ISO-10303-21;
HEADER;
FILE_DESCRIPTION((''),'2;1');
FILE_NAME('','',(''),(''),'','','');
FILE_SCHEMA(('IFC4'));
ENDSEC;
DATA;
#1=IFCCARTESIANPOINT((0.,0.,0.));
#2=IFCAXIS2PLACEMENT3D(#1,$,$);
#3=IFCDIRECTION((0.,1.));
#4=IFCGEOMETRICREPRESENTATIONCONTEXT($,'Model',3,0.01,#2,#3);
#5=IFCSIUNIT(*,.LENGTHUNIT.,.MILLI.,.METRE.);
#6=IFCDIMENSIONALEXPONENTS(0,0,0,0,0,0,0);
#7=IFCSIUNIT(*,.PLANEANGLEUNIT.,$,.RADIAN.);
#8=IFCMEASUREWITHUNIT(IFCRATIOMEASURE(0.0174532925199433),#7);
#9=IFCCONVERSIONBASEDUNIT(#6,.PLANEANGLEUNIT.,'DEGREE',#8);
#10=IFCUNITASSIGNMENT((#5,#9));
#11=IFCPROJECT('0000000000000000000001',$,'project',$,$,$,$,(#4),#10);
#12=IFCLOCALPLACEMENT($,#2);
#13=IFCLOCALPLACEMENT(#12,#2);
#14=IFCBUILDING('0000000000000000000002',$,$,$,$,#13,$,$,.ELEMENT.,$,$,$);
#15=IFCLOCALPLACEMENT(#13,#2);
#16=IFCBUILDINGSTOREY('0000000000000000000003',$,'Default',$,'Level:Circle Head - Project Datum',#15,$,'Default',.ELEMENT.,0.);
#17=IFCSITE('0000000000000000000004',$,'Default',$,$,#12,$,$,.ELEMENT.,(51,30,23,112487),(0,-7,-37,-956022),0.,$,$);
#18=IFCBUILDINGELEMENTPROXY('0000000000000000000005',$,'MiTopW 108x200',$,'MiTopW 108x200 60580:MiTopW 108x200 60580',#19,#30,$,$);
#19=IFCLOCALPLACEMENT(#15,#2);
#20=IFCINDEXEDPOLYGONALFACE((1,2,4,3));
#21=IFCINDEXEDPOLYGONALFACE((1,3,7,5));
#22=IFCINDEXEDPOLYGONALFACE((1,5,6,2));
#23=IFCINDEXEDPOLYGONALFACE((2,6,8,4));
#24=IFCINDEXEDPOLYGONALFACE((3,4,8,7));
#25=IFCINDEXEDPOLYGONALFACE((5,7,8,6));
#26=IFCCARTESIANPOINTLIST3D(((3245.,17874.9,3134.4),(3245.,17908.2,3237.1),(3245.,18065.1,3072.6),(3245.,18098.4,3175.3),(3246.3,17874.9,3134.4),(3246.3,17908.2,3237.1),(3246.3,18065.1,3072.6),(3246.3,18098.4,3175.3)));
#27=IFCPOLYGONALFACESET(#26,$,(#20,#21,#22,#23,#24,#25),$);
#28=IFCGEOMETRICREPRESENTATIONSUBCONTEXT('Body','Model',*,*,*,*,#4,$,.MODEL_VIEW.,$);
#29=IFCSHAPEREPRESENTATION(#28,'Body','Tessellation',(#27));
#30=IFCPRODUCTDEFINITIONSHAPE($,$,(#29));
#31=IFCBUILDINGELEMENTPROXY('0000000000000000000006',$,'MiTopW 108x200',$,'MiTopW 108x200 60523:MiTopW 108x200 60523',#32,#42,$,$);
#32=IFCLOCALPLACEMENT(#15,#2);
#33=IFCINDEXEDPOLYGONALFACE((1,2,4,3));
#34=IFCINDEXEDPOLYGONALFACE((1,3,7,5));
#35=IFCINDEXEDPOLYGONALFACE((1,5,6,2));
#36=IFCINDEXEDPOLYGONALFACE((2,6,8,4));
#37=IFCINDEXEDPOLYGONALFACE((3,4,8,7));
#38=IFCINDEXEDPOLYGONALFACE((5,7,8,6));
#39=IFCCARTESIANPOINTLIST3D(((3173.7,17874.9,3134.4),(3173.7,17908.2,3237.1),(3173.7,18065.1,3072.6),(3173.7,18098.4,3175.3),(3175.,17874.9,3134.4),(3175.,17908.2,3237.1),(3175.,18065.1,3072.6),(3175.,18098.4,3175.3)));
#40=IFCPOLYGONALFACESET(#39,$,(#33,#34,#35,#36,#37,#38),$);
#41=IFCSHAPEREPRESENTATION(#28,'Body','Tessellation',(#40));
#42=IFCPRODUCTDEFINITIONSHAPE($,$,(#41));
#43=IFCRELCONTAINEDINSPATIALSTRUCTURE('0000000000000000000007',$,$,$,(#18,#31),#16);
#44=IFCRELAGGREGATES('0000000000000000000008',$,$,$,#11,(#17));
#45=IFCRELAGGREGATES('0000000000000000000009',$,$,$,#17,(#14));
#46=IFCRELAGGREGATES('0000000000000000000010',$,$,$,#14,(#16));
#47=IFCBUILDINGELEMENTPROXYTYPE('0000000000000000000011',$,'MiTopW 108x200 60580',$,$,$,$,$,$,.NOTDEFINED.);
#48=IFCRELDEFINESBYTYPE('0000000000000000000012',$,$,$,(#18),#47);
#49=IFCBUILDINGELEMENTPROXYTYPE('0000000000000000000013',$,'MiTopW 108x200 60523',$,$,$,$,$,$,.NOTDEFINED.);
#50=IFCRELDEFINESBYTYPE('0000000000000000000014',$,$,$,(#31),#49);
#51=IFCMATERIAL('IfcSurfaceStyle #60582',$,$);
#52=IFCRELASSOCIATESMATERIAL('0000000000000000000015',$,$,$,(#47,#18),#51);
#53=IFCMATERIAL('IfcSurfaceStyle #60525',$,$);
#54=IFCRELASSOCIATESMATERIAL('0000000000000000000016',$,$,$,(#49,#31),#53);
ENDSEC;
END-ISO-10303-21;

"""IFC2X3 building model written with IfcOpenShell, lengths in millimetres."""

from ifc_helpers import new_model, entity, si_unit, converted_unit, direction, frame, origin, place, context, subcontext, project, spatial, polyline, outline, extrude, source, transform, mapped, material, type_object, type_shapes, element, save


model = new_model("IFC2X3")

# Units and contexts
model_context = context("Model", 3, precision=0.01, world=origin(), true_north=direction((0.0, 1.0)))
body_context = subcontext(model_context, "Body", "Model", "MODEL_VIEW")
ifc_project = project(units=[si_unit("LENGTHUNIT", "METRE", prefix="MILLI"), converted_unit("PLANEANGLEUNIT", "DEGREE", entity("IfcRatioMeasure", 0.0174532925199433), si_unit("PLANEANGLEUNIT", "RADIAN"), dimensions=[0, 0, 0, 0, 0, 0, 0])], contexts=[model_context])

# Site, building, storey
site_placement = place(None, origin())
site = spatial("IfcSite", under=ifc_project, at=site_placement, Name="Default", CompositionType="ELEMENT", RefLatitude=(51, 30, 23, 112487), RefLongitude=(0, -7, -37, -956022), RefElevation=0.0)
building_placement = place(site_placement, origin())
building = spatial("IfcBuilding", under=site, at=building_placement, CompositionType="ELEMENT")
storey_placement = place(building_placement, origin())
storey = spatial("IfcBuildingStorey", under=building, at=storey_placement, Name="Default", ObjectType="Level:Circle Head - Project Datum", LongName="Default", CompositionType="ELEMENT", Elevation=0.0)

# Building element proxies
ifc_material_1 = material(Name="IfcSurfaceStyle #60582")
building_element_proxy_type_1 = type_object("IfcBuildingElementProxyType", Name="MiTopW 108x200 60580", PredefinedType="NOTDEFINED", material=ifc_material_1)
shared_shape_1 = source(origin(), body_context, "Body", "SweptSolid", [
    extrude(outline(polyline([(-100.0, -54.0), (100.0, -54.0), (100.0, 54.0), (-100.0, 54.0), (-100.0, -54.0)])), frame((100.0, 54.0, 0.0), z_axis=(0.0, 0.0, 1.0), x_axis=(-1.0, 0.0, 0.0)), (0.0, 0.0, 1.0), 1.3),
])
type_shapes(building_element_proxy_type_1, [shared_shape_1])
proxy_1_placement = place(building_placement, frame((3246.3, 18065.1, 3072.6), z_axis=(-1.0, 0.0, 0.0), x_axis=(0.0, -0.951057, 0.309017)))
element("IfcBuildingElementProxy", 1, at=proxy_1_placement, inside=storey, type_object=building_element_proxy_type_1, material=ifc_material_1, Name="MiTopW 108x200", ObjectType="MiTopW 108x200 60580:MiTopW 108x200 60580", context=body_context, shape_type="MappedRepresentation", body=[
    mapped(shared_shape_1, transform((0.0, 0.0, 0.0), scale=1.0)),
])
ifc_material_2 = material(Name="IfcSurfaceStyle #60525")
building_element_proxy_type_2 = type_object("IfcBuildingElementProxyType", Name="MiTopW 108x200 60523", PredefinedType="NOTDEFINED", material=ifc_material_2)
shared_shape_2 = source(origin(), body_context, "Body", "SweptSolid", [
    extrude(outline(polyline([(-100.0, -54.0), (100.0, -54.0), (100.0, 54.0), (-100.0, 54.0), (-100.0, -54.0)])), frame((100.0, 54.0, 0.0), z_axis=(0.0, 0.0, 1.0), x_axis=(-1.0, 0.0, 0.0)), (0.0, 0.0, 1.0), 1.3),
])
type_shapes(building_element_proxy_type_2, [shared_shape_2])
proxy_2_placement = place(building_placement, frame((3175.0, 18065.1, 3072.6), z_axis=(-1.0, 0.0, 0.0), x_axis=(0.0, -0.951057, 0.309017)))
element("IfcBuildingElementProxy", 2, at=proxy_2_placement, inside=storey, type_object=building_element_proxy_type_2, material=ifc_material_2, Name="MiTopW 108x200", ObjectType="MiTopW 108x200 60523:MiTopW 108x200 60523", context=body_context, shape_type="MappedRepresentation", body=[
    mapped(shared_shape_2, transform((0.0, 0.0, 0.0), scale=1.0)),
])

save(model, "model.ifc")
